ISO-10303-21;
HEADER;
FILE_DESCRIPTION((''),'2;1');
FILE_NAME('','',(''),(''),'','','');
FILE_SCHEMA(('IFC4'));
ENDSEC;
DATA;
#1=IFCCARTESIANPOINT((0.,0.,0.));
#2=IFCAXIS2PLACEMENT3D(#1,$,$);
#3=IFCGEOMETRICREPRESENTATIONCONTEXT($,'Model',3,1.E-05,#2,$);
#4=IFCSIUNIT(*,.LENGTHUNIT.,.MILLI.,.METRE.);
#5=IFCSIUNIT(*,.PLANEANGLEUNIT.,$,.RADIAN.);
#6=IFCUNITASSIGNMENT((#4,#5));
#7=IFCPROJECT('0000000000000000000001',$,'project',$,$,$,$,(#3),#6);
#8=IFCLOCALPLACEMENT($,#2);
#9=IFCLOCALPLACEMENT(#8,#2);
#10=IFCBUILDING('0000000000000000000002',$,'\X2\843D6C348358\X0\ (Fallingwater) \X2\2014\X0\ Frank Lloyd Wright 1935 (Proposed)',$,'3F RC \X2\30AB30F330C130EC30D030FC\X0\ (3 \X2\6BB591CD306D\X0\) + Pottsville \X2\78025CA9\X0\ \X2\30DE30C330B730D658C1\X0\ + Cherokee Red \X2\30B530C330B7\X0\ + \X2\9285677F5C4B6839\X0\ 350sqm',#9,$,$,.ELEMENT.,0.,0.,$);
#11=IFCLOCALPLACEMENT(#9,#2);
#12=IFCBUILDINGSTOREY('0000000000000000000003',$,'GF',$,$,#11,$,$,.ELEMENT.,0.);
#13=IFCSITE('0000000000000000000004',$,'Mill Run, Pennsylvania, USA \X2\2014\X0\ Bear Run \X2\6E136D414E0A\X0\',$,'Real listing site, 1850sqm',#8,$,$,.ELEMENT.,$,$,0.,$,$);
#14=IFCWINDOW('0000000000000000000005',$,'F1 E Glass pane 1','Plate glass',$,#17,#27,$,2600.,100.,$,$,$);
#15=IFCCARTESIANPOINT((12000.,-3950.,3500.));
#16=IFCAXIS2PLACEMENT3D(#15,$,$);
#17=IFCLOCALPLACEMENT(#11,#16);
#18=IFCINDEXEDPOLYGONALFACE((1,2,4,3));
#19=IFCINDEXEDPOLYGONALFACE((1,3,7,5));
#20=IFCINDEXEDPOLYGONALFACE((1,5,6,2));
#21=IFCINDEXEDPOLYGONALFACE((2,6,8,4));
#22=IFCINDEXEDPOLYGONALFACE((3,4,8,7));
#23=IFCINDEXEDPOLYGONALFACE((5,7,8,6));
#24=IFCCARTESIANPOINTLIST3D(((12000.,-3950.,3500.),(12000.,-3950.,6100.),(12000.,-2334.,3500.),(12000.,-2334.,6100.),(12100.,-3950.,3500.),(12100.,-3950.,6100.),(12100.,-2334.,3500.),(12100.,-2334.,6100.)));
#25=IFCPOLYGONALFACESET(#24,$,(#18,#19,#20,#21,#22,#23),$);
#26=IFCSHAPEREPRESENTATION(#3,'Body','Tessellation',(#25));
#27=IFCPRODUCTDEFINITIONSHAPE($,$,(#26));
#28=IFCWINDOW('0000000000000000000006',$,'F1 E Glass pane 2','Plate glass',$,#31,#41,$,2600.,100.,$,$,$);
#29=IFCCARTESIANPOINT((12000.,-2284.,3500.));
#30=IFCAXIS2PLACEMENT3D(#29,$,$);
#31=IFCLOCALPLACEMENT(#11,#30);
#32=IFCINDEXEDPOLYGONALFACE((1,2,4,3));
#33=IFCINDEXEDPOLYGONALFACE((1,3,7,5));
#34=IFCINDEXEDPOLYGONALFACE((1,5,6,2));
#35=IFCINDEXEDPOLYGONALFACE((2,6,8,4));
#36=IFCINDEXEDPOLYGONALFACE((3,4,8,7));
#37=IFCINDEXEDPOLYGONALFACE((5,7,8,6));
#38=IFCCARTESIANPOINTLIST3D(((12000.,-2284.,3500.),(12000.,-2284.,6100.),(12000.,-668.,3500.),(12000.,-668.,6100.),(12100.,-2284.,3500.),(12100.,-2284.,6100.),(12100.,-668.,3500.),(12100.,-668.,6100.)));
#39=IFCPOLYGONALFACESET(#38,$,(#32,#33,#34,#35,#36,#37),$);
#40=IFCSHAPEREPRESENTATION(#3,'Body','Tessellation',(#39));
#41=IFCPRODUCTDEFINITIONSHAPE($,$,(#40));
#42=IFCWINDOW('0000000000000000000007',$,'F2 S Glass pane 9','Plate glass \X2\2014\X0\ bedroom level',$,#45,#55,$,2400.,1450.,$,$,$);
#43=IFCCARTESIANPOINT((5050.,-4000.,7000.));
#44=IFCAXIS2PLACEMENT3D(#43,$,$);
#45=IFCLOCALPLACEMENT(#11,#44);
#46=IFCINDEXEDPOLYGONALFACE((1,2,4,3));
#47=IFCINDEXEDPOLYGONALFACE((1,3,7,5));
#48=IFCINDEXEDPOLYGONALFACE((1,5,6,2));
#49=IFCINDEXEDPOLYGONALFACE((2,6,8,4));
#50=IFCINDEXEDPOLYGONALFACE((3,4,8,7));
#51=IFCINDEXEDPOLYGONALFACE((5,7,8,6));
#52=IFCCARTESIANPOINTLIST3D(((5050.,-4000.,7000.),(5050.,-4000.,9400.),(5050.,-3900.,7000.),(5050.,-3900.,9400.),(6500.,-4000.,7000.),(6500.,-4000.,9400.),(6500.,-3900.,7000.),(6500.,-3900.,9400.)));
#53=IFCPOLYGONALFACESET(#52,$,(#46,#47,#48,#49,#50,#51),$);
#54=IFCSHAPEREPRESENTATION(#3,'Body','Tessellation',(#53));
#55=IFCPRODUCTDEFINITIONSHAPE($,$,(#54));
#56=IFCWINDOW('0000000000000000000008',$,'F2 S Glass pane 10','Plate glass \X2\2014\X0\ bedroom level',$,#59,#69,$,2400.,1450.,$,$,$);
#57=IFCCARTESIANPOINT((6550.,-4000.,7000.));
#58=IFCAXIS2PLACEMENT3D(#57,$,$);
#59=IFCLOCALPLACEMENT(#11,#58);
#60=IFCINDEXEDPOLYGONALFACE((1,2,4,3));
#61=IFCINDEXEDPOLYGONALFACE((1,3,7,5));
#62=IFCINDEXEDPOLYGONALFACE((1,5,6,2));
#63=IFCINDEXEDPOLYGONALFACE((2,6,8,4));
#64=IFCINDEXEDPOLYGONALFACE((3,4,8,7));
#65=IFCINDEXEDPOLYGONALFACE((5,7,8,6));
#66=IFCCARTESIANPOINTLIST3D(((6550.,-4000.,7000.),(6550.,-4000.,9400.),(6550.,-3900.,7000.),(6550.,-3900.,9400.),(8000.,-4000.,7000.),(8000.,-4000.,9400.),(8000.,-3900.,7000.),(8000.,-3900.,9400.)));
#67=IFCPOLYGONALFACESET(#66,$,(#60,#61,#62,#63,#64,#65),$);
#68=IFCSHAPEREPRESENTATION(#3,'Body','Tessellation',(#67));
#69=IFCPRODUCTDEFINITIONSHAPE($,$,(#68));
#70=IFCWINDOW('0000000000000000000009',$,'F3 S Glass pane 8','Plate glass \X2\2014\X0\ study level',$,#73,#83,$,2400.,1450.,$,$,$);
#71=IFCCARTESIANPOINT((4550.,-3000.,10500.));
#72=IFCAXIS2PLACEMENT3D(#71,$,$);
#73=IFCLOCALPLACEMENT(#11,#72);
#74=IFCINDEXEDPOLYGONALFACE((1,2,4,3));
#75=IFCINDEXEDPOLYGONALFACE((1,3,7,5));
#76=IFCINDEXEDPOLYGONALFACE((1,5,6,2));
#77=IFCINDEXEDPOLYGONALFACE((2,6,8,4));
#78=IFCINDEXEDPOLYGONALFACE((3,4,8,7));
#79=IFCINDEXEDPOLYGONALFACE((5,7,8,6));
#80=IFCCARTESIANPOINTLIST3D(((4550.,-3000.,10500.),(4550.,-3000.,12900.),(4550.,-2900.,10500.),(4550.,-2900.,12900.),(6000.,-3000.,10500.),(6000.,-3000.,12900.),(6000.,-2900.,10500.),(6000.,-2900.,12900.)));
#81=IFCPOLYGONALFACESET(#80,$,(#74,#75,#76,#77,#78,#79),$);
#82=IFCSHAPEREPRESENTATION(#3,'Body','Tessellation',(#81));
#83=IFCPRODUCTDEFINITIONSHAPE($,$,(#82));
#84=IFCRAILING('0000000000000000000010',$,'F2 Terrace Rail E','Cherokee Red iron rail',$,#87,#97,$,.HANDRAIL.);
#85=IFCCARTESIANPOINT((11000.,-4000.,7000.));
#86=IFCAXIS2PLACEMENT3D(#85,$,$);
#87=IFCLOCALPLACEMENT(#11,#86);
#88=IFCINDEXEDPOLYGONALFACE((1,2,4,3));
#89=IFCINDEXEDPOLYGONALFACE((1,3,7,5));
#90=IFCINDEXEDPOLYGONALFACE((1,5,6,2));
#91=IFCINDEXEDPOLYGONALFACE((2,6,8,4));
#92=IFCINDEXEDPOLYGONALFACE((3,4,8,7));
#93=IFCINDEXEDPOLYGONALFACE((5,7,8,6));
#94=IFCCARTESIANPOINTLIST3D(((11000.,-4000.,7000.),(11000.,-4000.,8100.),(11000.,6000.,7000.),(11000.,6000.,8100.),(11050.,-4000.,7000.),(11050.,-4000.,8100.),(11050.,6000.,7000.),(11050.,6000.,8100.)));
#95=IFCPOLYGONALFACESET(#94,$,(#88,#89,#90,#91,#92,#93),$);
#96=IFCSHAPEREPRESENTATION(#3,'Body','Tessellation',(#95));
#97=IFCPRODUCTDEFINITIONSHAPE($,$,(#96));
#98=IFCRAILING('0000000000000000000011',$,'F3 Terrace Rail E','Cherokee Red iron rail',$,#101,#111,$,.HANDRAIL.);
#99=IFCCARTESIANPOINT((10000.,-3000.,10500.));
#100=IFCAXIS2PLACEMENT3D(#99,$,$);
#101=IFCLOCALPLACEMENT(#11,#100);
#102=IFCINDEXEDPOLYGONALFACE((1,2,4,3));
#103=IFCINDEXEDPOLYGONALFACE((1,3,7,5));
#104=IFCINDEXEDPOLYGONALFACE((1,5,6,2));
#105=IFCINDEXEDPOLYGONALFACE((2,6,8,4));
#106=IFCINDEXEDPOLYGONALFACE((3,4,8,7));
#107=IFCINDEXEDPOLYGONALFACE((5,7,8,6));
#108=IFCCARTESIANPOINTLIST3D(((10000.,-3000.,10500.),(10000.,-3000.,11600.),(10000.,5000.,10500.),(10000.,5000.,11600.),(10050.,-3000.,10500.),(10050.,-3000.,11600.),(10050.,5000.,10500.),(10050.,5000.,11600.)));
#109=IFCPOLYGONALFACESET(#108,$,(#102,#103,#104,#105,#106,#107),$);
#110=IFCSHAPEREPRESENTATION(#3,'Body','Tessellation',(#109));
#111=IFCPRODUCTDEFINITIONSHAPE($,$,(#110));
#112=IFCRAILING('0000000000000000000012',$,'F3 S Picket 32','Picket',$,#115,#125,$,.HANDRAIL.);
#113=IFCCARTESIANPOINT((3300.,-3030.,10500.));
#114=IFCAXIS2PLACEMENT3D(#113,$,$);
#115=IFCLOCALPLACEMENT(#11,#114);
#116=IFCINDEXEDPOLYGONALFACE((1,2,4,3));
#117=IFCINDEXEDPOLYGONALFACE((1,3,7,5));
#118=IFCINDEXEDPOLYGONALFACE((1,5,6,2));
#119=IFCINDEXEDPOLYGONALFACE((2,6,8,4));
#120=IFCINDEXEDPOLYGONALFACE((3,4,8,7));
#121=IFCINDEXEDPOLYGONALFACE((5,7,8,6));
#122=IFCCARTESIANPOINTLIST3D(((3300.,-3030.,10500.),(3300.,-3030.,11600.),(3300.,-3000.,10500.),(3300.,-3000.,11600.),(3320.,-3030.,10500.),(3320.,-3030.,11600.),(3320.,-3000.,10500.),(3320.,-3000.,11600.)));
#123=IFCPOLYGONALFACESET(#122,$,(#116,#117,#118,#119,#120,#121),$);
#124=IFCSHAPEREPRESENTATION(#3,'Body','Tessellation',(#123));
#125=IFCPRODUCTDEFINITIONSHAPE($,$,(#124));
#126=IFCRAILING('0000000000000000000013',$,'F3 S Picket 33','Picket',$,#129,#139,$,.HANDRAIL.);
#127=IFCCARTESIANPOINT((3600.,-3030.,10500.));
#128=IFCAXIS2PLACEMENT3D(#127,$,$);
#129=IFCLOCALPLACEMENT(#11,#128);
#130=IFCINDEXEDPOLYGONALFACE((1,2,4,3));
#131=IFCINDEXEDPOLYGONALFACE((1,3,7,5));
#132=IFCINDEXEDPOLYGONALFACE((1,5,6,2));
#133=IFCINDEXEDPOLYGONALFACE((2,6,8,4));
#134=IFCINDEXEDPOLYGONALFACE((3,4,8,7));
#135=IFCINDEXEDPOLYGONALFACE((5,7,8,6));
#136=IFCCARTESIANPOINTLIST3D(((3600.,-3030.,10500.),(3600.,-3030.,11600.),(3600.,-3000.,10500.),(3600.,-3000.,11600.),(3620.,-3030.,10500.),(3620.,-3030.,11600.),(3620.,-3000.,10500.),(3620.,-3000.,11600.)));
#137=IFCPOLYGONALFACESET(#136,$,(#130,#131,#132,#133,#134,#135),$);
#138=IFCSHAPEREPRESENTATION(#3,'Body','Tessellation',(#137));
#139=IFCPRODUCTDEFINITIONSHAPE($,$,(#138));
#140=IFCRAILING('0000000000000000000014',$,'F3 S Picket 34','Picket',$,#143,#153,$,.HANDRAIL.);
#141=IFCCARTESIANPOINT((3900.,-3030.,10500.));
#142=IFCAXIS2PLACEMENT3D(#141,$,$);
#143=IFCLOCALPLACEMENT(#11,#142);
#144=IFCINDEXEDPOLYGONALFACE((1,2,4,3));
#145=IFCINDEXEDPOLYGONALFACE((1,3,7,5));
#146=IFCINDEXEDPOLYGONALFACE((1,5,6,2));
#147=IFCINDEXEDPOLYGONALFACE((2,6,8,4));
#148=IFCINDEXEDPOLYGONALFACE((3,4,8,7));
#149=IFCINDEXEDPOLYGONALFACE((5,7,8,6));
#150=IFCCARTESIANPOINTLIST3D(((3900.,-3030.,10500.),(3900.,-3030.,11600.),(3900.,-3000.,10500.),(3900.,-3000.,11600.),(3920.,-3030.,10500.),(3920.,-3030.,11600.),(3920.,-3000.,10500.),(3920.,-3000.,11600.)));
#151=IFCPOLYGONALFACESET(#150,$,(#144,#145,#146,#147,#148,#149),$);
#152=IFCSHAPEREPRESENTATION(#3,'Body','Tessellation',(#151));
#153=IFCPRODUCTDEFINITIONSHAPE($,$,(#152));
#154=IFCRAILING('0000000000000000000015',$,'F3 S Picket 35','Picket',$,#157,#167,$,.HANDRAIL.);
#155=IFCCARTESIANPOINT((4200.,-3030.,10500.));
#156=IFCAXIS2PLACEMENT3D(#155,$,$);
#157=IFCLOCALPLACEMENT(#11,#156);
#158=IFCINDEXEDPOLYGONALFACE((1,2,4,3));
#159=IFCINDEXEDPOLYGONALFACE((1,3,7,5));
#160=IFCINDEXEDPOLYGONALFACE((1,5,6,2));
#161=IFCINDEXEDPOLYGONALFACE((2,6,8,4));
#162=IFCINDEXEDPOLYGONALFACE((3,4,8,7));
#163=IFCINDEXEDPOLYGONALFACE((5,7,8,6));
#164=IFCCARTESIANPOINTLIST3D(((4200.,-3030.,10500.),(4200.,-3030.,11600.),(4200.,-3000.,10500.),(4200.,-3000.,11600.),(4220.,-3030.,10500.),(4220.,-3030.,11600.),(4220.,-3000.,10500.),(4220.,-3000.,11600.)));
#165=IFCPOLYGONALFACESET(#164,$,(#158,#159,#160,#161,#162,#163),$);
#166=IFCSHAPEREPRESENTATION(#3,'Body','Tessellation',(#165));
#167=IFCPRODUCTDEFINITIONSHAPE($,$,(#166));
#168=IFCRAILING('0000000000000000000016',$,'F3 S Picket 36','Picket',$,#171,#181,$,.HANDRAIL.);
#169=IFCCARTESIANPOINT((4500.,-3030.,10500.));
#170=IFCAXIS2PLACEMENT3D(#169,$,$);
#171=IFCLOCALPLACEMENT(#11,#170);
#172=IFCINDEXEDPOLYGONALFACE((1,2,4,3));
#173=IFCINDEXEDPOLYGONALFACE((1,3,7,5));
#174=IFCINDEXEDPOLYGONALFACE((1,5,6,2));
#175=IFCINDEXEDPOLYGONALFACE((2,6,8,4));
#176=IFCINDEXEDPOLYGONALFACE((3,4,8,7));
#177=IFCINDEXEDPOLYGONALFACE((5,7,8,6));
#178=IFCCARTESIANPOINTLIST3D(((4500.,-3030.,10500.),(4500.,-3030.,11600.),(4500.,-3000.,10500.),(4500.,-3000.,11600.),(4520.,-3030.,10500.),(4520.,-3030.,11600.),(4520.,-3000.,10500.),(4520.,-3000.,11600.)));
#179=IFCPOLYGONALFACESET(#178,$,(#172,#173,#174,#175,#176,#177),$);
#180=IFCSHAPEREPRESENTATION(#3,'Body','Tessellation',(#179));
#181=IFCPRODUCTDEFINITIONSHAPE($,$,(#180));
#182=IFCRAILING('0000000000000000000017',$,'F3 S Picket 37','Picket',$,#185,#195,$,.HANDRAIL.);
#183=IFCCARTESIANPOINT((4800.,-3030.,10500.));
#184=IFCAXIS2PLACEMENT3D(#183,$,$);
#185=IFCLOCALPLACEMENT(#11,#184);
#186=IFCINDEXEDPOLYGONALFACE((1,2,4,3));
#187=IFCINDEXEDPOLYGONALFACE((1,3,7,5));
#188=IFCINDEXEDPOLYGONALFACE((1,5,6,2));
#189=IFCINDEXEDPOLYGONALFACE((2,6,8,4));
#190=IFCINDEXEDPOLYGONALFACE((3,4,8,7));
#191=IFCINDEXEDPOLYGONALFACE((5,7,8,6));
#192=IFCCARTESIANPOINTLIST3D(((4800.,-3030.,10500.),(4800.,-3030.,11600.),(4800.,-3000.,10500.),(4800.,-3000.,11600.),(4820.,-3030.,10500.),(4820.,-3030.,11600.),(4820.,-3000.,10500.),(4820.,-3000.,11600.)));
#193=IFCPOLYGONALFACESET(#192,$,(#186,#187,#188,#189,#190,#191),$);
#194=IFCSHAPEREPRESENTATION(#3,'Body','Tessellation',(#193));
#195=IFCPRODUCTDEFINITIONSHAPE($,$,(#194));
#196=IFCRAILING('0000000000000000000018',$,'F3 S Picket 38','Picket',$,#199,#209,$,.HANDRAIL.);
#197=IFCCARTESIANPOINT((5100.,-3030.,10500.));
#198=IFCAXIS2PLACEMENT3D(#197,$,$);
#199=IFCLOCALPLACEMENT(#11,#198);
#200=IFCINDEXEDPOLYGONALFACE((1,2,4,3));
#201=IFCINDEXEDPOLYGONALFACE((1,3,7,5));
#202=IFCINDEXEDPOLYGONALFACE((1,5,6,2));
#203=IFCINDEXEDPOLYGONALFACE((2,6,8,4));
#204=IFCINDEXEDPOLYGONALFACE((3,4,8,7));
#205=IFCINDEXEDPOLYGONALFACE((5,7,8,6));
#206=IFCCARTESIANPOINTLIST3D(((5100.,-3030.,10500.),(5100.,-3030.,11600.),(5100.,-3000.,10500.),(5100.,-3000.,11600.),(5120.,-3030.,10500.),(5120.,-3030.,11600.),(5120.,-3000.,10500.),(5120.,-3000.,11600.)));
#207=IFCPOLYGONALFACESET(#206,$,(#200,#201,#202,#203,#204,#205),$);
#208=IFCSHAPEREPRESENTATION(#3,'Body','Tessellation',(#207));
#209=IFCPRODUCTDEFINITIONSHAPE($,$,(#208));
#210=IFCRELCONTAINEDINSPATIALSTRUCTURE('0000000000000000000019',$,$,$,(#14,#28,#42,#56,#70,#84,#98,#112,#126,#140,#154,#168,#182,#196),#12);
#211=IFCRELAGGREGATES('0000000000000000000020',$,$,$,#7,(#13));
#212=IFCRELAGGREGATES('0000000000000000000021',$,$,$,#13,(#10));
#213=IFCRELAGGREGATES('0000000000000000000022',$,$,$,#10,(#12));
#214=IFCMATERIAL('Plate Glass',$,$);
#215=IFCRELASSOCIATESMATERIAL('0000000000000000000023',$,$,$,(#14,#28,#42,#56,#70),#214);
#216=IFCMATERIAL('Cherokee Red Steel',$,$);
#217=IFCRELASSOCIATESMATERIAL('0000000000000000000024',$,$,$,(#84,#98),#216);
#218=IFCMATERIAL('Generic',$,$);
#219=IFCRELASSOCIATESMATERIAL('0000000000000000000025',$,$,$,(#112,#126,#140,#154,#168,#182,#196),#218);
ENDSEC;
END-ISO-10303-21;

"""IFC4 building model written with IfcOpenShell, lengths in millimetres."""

from ifc_helpers import new_model, si_unit, frame, frame_2d, origin, place, context, project, spatial, rectangle, extrude, material, element, save


model = new_model("IFC4")

# Units and contexts
model_context = context("Model", 3, precision=1e-05, world=origin())
ifc_project = project(units=[si_unit("LENGTHUNIT", "METRE", prefix="MILLI"), si_unit("PLANEANGLEUNIT", "RADIAN")], contexts=[model_context])

# Site, building, storey
site_placement = place(None, origin())
site = spatial("IfcSite", under=ifc_project, at=site_placement, Name="Mill Run, Pennsylvania, USA — Bear Run 渓流上", ObjectType="Real listing site, 1850sqm", CompositionType="ELEMENT", RefElevation=0.0)
building_placement = place(site_placement, origin())
building = spatial("IfcBuilding", under=site, at=building_placement, Name="落水荘 (Fallingwater) — Frank Lloyd Wright 1935 (Proposed)", ObjectType="3F RC カンチレバー (3 段重ね) + Pottsville 砂岩 マッシブ壁 + Cherokee Red サッシ + 銅板屋根 350sqm", CompositionType="ELEMENT", ElevationOfRefHeight=0.0, ElevationOfTerrain=0.0)
storey_placement = place(building_placement, origin())
storey = spatial("IfcBuildingStorey", under=building, at=storey_placement, Name="GF", CompositionType="ELEMENT", Elevation=0.0)

# Windows
ifc_material_1 = material(Name="Plate Glass")
window_1_placement = place(storey_placement, frame((12000.0, -3950.0, 3500.0)))
element("IfcWindow", 1, at=window_1_placement, inside=storey, material=ifc_material_1, Name="F1 E Glass pane 1", Description="Plate glass", OverallHeight=2600.0, OverallWidth=100.0, context=model_context, shape_type="SweptSolid", body=[
    extrude(rectangle(XDim=100.0, YDim=1616.0, at=frame_2d((50.0, 808.0))), frame((12000.0, -3950.0, 3500.0)), (0.0, 0.0, 1.0), 2600.0),
])
window_2_placement = place(storey_placement, frame((12000.0, -2284.0, 3500.0)))
element("IfcWindow", 2, at=window_2_placement, inside=storey, material=ifc_material_1, Name="F1 E Glass pane 2", Description="Plate glass", OverallHeight=2600.0, OverallWidth=100.0, context=model_context, shape_type="SweptSolid", body=[
    extrude(rectangle(XDim=100.0, YDim=1616.0, at=frame_2d((50.0, 808.0))), frame((12000.0, -2284.0, 3500.0)), (0.0, 0.0, 1.0), 2600.0),
])
window_3_placement = place(storey_placement, frame((5050.0, -4000.0, 7000.0)))
element("IfcWindow", 3, at=window_3_placement, inside=storey, material=ifc_material_1, Name="F2 S Glass pane 9", Description="Plate glass — bedroom level", OverallHeight=2400.0, OverallWidth=1450.0, context=model_context, shape_type="SweptSolid", body=[
    extrude(rectangle(XDim=1450.0, YDim=100.0, at=frame_2d((725.0, 50.0))), frame((5050.0, -4000.0, 7000.0)), (0.0, 0.0, 1.0), 2400.0),
])
window_4_placement = place(storey_placement, frame((6550.0, -4000.0, 7000.0)))
element("IfcWindow", 4, at=window_4_placement, inside=storey, material=ifc_material_1, Name="F2 S Glass pane 10", Description="Plate glass — bedroom level", OverallHeight=2400.0, OverallWidth=1450.0, context=model_context, shape_type="SweptSolid", body=[
    extrude(rectangle(XDim=1450.0, YDim=100.0, at=frame_2d((725.0, 50.0))), frame((6550.0, -4000.0, 7000.0)), (0.0, 0.0, 1.0), 2400.0),
])
window_5_placement = place(storey_placement, frame((4550.0, -3000.0, 10500.0)))
element("IfcWindow", 5, at=window_5_placement, inside=storey, material=ifc_material_1, Name="F3 S Glass pane 8", Description="Plate glass — study level", OverallHeight=2400.0, OverallWidth=1450.0, context=model_context, shape_type="SweptSolid", body=[
    extrude(rectangle(XDim=1450.0, YDim=100.0, at=frame_2d((725.0, 50.0))), frame((4550.0, -3000.0, 10500.0)), (0.0, 0.0, 1.0), 2400.0),
])

# Railings
ifc_material_2 = material(Name="Cherokee Red Steel")
railing_1_placement = place(storey_placement, frame((11000.0, -4000.0, 7000.0)))
element("IfcRailing", 6, at=railing_1_placement, inside=storey, material=ifc_material_2, Name="F2 Terrace Rail E", Description="Cherokee Red iron rail", PredefinedType="HANDRAIL", context=model_context, shape_type="SweptSolid", body=[
    extrude(rectangle(XDim=50.0, YDim=10000.0, at=frame_2d((25.0, 5000.0))), frame((11000.0, -4000.0, 7000.0)), (0.0, 0.0, 1.0), 1100.0),
])
railing_2_placement = place(storey_placement, frame((10000.0, -3000.0, 10500.0)))
element("IfcRailing", 7, at=railing_2_placement, inside=storey, material=ifc_material_2, Name="F3 Terrace Rail E", Description="Cherokee Red iron rail", PredefinedType="HANDRAIL", context=model_context, shape_type="SweptSolid", body=[
    extrude(rectangle(XDim=50.0, YDim=8000.0, at=frame_2d((25.0, 4000.0))), frame((10000.0, -3000.0, 10500.0)), (0.0, 0.0, 1.0), 1100.0),
])
ifc_material_3 = material(Name="Generic")
railing_3_placement = place(storey_placement, frame((3300.0, -3030.0, 10500.0)))
element("IfcRailing", 8, at=railing_3_placement, inside=storey, material=ifc_material_3, Name="F3 S Picket 32", Description="Picket", PredefinedType="HANDRAIL", context=model_context, shape_type="SweptSolid", body=[
    extrude(rectangle(XDim=20.0, YDim=30.0, at=frame_2d((10.0, 15.0))), frame((3300.0, -3030.0, 10500.0)), (0.0, 0.0, 1.0), 1100.0),
])
railing_4_placement = place(storey_placement, frame((3600.0, -3030.0, 10500.0)))
element("IfcRailing", 9, at=railing_4_placement, inside=storey, material=ifc_material_3, Name="F3 S Picket 33", Description="Picket", PredefinedType="HANDRAIL", context=model_context, shape_type="SweptSolid", body=[
    extrude(rectangle(XDim=20.0, YDim=30.0, at=frame_2d((10.0, 15.0))), frame((3600.0, -3030.0, 10500.0)), (0.0, 0.0, 1.0), 1100.0),
])
railing_5_placement = place(storey_placement, frame((3900.0, -3030.0, 10500.0)))
element("IfcRailing", 10, at=railing_5_placement, inside=storey, material=ifc_material_3, Name="F3 S Picket 34", Description="Picket", PredefinedType="HANDRAIL", context=model_context, shape_type="SweptSolid", body=[
    extrude(rectangle(XDim=20.0, YDim=30.0, at=frame_2d((10.0, 15.0))), frame((3900.0, -3030.0, 10500.0)), (0.0, 0.0, 1.0), 1100.0),
])
railing_6_placement = place(storey_placement, frame((4200.0, -3030.0, 10500.0)))
element("IfcRailing", 11, at=railing_6_placement, inside=storey, material=ifc_material_3, Name="F3 S Picket 35", Description="Picket", PredefinedType="HANDRAIL", context=model_context, shape_type="SweptSolid", body=[
    extrude(rectangle(XDim=20.0, YDim=30.0, at=frame_2d((10.0, 15.0))), frame((4200.0, -3030.0, 10500.0)), (0.0, 0.0, 1.0), 1100.0),
])
railing_7_placement = place(storey_placement, frame((4500.0, -3030.0, 10500.0)))
element("IfcRailing", 12, at=railing_7_placement, inside=storey, material=ifc_material_3, Name="F3 S Picket 36", Description="Picket", PredefinedType="HANDRAIL", context=model_context, shape_type="SweptSolid", body=[
    extrude(rectangle(XDim=20.0, YDim=30.0, at=frame_2d((10.0, 15.0))), frame((4500.0, -3030.0, 10500.0)), (0.0, 0.0, 1.0), 1100.0),
])
railing_8_placement = place(storey_placement, frame((4800.0, -3030.0, 10500.0)))
element("IfcRailing", 13, at=railing_8_placement, inside=storey, material=ifc_material_3, Name="F3 S Picket 37", Description="Picket", PredefinedType="HANDRAIL", context=model_context, shape_type="SweptSolid", body=[
    extrude(rectangle(XDim=20.0, YDim=30.0, at=frame_2d((10.0, 15.0))), frame((4800.0, -3030.0, 10500.0)), (0.0, 0.0, 1.0), 1100.0),
])
railing_9_placement = place(storey_placement, frame((5100.0, -3030.0, 10500.0)))
element("IfcRailing", 14, at=railing_9_placement, inside=storey, material=ifc_material_3, Name="F3 S Picket 38", Description="Picket", PredefinedType="HANDRAIL", context=model_context, shape_type="SweptSolid", body=[
    extrude(rectangle(XDim=20.0, YDim=30.0, at=frame_2d((10.0, 15.0))), frame((5100.0, -3030.0, 10500.0)), (0.0, 0.0, 1.0), 1100.0),
])

save(model, "model.ifc")
